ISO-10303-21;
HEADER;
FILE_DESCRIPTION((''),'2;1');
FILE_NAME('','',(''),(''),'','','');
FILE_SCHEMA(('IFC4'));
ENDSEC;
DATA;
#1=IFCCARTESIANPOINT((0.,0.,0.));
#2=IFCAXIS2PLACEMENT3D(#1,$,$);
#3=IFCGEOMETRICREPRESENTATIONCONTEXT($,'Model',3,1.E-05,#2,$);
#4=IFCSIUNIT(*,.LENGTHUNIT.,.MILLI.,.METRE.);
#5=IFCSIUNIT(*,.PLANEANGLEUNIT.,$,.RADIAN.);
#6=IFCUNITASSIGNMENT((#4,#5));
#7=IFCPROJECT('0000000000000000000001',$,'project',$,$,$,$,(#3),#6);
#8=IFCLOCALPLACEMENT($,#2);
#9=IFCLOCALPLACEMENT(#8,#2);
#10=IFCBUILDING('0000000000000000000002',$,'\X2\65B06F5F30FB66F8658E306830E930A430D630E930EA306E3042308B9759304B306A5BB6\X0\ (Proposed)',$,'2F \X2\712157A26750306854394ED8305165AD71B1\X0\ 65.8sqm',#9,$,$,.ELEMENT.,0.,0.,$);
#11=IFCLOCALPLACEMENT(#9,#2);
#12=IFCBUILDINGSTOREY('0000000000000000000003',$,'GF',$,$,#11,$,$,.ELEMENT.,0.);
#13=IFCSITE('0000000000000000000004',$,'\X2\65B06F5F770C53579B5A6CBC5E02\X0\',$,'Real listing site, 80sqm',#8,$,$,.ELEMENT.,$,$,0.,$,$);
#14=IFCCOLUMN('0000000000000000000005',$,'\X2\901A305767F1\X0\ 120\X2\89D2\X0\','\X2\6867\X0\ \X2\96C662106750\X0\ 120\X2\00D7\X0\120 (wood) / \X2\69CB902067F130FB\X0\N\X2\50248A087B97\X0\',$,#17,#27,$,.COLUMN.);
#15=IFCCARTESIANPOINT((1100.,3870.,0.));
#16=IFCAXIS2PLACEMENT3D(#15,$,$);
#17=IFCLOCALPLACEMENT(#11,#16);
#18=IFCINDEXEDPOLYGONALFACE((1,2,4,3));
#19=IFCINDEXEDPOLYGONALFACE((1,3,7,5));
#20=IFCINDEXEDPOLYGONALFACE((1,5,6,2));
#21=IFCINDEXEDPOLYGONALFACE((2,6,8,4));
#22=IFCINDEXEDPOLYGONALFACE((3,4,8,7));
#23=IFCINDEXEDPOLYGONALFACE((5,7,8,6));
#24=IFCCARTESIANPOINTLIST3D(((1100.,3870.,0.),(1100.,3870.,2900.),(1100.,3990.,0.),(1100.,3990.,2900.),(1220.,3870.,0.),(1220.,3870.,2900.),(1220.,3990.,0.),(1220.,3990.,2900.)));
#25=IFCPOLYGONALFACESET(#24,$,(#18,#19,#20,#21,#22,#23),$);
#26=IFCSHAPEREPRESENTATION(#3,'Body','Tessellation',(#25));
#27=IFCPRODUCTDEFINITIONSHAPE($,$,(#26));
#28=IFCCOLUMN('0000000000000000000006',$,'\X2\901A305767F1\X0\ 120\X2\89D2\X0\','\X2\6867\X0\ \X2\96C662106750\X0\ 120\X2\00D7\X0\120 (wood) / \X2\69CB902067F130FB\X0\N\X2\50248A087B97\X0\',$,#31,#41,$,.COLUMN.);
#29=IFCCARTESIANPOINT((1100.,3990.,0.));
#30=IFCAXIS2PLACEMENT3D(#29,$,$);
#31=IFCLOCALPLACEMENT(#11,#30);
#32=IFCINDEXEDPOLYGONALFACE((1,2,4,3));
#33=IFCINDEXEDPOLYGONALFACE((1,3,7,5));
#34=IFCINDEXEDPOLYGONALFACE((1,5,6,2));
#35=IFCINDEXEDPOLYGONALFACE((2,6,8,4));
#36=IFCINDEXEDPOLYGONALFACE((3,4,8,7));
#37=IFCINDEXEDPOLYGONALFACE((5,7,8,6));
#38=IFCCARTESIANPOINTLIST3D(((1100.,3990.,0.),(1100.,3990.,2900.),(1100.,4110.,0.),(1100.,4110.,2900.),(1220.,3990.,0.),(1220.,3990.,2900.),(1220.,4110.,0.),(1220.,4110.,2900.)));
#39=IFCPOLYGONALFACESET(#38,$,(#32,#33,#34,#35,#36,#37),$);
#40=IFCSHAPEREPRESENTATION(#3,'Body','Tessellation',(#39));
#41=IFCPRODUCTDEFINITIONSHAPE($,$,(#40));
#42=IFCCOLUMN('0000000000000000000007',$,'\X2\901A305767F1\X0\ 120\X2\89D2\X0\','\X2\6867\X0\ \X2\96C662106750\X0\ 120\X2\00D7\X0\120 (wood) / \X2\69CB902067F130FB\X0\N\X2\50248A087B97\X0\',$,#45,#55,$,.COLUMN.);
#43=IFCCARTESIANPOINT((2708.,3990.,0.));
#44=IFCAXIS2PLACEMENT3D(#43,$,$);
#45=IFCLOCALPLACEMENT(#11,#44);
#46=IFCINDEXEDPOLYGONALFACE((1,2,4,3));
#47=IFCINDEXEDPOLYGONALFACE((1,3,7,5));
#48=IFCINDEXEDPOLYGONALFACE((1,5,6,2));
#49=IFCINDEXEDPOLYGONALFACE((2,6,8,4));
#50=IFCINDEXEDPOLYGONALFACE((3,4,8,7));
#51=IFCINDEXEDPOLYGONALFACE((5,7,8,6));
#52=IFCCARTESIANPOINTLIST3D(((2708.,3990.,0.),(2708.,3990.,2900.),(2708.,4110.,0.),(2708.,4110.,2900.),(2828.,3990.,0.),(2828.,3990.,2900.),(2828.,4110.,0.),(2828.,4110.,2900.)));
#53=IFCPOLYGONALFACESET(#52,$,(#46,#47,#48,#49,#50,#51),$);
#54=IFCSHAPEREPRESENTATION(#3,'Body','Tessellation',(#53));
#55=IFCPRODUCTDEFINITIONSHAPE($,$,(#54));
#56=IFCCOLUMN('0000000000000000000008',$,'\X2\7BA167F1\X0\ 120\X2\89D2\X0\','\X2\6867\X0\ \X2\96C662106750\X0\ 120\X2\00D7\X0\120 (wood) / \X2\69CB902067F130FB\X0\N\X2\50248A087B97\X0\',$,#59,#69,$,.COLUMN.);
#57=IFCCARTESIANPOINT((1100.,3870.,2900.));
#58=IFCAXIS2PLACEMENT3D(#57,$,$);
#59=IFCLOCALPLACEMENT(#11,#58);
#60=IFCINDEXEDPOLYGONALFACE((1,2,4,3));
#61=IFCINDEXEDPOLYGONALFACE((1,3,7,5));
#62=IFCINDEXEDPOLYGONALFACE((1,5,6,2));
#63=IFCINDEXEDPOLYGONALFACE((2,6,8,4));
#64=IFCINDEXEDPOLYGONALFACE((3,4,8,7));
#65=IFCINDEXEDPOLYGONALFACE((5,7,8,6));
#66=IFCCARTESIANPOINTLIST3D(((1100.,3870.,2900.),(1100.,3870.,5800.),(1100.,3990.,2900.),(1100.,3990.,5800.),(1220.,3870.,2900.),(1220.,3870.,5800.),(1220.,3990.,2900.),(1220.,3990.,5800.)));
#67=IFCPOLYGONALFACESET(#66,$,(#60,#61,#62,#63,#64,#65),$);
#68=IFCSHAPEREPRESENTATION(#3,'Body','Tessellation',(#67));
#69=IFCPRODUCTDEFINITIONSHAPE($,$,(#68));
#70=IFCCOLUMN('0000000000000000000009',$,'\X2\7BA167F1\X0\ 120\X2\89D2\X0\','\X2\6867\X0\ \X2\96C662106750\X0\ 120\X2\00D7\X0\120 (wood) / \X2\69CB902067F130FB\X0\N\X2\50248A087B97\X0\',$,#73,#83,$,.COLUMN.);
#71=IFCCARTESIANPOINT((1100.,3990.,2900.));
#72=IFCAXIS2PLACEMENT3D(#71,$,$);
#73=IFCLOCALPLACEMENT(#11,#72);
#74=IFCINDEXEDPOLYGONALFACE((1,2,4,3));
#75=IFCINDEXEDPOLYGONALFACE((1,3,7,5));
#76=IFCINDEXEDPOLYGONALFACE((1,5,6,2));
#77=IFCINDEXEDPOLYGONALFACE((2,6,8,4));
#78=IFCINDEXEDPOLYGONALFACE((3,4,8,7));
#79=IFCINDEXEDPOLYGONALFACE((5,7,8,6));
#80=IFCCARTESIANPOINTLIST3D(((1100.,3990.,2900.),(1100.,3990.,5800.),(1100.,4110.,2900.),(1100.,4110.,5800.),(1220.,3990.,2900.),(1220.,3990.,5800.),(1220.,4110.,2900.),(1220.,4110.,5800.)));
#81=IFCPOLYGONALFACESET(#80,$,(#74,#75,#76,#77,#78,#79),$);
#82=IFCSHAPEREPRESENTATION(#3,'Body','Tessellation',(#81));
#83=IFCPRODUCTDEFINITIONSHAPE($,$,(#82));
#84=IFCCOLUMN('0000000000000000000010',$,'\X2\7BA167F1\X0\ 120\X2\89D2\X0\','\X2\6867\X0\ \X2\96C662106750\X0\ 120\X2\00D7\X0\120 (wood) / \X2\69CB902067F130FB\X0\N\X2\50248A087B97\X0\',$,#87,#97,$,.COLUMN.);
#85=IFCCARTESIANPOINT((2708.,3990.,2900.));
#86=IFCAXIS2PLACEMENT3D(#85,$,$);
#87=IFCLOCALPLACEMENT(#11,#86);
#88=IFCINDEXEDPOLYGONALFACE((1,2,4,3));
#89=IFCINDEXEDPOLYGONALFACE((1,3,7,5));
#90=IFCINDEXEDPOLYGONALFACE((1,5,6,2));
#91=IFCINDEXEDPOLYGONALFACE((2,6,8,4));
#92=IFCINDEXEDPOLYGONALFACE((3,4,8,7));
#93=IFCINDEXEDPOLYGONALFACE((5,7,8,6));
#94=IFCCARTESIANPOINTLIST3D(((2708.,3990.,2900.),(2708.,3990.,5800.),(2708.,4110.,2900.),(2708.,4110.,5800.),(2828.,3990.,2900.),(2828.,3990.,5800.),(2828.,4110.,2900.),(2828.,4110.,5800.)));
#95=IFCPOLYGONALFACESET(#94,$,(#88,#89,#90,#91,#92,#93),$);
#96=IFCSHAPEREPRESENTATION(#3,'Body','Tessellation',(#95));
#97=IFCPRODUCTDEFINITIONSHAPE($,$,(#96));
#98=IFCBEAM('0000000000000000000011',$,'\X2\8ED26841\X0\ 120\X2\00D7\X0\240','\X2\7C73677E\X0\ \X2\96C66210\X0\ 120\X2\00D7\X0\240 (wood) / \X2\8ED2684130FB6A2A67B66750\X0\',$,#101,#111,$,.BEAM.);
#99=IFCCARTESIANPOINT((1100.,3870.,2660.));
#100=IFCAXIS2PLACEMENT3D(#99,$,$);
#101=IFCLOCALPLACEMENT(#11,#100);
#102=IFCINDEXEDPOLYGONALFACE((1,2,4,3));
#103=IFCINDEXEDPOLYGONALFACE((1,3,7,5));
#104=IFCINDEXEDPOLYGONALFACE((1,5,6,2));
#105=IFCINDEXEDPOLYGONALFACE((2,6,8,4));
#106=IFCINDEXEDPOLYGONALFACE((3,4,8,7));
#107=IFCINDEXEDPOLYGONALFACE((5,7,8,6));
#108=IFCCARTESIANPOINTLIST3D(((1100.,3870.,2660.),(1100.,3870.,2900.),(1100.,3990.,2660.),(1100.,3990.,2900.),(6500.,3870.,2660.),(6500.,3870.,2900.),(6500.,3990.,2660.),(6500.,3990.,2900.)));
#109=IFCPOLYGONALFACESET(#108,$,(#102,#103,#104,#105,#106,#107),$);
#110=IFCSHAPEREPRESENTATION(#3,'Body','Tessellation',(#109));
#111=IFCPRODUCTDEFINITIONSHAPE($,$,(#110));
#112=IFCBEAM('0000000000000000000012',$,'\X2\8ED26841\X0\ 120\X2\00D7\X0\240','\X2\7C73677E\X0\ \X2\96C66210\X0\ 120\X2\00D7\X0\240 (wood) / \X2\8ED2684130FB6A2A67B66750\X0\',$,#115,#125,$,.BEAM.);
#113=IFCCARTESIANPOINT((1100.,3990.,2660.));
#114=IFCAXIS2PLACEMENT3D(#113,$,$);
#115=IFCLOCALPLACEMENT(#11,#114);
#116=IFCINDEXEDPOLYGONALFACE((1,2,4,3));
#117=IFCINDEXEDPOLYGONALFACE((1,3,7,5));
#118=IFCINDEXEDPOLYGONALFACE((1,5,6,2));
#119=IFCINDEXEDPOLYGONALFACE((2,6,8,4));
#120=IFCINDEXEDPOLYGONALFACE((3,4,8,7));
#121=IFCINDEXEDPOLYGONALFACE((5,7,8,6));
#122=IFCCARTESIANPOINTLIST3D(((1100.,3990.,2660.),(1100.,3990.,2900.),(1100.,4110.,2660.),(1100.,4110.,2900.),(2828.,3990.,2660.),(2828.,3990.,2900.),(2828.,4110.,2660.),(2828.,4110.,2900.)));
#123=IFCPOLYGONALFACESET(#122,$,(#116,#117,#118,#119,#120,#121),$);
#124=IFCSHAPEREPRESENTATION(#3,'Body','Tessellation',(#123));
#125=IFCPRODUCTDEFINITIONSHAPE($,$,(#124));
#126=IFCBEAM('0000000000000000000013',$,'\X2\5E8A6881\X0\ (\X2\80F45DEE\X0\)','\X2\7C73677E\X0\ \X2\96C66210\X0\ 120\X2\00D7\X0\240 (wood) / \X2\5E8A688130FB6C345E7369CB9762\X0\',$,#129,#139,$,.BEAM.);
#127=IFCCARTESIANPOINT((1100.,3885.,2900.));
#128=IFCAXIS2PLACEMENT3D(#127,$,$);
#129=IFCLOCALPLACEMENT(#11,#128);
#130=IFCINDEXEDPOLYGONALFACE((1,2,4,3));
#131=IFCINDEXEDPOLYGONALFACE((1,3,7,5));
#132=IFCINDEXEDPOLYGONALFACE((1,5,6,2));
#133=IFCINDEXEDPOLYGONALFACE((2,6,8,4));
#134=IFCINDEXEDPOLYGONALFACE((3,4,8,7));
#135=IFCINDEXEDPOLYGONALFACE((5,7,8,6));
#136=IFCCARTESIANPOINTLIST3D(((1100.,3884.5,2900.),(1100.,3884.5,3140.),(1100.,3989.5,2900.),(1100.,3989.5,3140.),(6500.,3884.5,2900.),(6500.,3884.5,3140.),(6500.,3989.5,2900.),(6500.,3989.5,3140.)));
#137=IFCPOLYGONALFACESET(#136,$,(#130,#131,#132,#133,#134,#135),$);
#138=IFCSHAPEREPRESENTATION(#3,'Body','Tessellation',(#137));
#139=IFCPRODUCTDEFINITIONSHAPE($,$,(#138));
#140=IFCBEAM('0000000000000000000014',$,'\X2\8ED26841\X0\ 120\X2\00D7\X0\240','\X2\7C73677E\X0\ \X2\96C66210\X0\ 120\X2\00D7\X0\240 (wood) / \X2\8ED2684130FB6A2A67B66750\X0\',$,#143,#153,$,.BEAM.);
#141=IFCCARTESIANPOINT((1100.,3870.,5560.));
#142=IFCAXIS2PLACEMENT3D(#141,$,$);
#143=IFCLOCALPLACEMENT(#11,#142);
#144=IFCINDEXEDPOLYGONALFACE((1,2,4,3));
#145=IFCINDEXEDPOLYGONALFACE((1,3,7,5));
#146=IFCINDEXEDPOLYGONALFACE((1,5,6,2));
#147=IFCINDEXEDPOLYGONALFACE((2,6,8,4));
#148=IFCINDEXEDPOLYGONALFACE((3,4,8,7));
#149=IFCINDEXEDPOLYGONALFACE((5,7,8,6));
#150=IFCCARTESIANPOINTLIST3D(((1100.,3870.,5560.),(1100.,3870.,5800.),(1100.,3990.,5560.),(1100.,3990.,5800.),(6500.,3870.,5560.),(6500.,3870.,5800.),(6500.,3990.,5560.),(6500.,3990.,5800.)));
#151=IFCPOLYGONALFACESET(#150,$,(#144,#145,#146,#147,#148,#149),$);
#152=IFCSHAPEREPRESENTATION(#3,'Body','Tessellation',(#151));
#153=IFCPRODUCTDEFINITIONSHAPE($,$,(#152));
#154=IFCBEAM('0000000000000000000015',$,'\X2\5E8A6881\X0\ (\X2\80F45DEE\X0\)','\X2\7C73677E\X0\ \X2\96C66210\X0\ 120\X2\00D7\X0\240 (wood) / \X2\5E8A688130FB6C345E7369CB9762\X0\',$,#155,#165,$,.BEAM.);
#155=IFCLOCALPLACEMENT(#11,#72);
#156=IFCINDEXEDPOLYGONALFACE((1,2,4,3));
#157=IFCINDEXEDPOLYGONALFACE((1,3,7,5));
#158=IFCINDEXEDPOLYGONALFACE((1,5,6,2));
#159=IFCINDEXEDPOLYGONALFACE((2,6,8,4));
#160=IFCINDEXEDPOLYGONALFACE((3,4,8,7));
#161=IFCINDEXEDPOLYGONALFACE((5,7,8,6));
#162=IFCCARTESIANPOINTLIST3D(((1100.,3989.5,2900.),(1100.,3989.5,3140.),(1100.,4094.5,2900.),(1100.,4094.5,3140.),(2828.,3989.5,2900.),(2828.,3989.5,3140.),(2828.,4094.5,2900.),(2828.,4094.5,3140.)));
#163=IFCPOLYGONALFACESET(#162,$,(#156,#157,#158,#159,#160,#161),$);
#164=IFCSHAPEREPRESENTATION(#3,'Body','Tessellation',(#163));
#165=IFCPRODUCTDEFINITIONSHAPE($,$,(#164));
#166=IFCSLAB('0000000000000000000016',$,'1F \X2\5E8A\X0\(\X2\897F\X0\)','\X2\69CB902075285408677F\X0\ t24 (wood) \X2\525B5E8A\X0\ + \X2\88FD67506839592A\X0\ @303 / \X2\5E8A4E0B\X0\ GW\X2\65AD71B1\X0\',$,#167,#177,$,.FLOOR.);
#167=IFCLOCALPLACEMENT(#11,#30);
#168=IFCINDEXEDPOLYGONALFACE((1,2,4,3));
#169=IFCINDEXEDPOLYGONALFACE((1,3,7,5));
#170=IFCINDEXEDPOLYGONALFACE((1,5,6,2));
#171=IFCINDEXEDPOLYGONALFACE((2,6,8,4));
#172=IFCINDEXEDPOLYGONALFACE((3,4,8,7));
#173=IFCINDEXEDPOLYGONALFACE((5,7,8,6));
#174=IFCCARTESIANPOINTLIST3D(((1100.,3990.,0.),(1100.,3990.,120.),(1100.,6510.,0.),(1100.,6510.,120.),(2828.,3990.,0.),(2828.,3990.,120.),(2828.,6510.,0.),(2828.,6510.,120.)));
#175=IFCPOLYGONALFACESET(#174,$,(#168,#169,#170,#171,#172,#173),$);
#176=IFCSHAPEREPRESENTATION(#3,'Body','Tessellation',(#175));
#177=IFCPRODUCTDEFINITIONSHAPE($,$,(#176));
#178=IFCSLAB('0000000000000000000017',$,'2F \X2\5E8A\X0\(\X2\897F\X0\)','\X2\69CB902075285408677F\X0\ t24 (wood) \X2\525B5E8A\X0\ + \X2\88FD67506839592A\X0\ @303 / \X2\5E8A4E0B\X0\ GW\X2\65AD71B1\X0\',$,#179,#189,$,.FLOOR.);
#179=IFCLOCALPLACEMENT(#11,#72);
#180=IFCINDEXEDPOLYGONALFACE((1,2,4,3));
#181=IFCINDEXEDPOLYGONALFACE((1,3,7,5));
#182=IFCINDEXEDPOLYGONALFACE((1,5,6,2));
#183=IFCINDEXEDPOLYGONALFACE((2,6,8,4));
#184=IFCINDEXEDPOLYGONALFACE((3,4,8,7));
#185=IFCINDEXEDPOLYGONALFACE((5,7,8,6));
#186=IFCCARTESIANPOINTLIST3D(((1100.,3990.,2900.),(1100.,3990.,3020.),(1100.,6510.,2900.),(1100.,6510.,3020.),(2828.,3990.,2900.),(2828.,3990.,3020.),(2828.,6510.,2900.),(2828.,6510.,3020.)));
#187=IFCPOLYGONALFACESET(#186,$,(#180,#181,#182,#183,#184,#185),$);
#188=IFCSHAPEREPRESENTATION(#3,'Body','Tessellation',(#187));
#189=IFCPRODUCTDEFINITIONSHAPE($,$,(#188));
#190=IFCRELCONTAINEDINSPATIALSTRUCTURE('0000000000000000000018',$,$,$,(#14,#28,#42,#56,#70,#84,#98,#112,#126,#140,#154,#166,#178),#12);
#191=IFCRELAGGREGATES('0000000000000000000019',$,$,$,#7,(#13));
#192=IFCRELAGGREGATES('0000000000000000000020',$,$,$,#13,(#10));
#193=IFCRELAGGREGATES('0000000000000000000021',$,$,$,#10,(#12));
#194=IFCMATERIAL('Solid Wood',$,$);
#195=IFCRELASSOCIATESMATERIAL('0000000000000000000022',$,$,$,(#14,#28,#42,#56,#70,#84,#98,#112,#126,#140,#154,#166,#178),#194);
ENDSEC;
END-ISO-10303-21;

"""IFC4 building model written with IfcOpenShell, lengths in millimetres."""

from ifc_helpers import new_model, si_unit, frame, frame_2d, origin, place, context, project, spatial, rectangle, extrude, material, element, save


model = new_model("IFC4")

# Units and contexts
model_context = context("Model", 3, precision=1e-05, world=origin())
ifc_project = project(units=[si_unit("LENGTHUNIT", "METRE", prefix="MILLI"), si_unit("PLANEANGLEUNIT", "RADIAN")], contexts=[model_context])

# Site, building, storey
site_placement = place(None, origin())
site = spatial("IfcSite", under=ifc_project, at=site_placement, Name="新潟県南魚沼市", ObjectType="Real listing site, 80sqm", CompositionType="ELEMENT", RefElevation=0.0)
building_placement = place(site_placement, origin())
building = spatial("IfcBuilding", under=site, at=building_placement, Name="新潟・書斎とライブラリのある静かな家 (Proposed)", ObjectType="2F 無垢材と吹付け断熱 65.8sqm", CompositionType="ELEMENT", ElevationOfRefHeight=0.0, ElevationOfTerrain=0.0)
storey_placement = place(building_placement, origin())
storey = spatial("IfcBuildingStorey", under=building, at=storey_placement, Name="GF", CompositionType="ELEMENT", Elevation=0.0)

# Columns
ifc_material_1 = material(Name="Solid Wood")
column_1_placement = place(storey_placement, frame((1100.0, 3870.0, 0.0)))
element("IfcColumn", 1, at=column_1_placement, inside=storey, material=ifc_material_1, Name="通し柱 120角", Description="桧 集成材 120×120 (wood) / 構造柱・N値計算", PredefinedType="COLUMN", context=model_context, shape_type="SweptSolid", body=[
    extrude(rectangle(XDim=120.0, YDim=120.0, at=frame_2d((60.0, 60.0))), frame((1100.0, 3870.0, 0.0)), (0.0, 0.0, 1.0), 2900.0),
])
column_2_placement = place(storey_placement, frame((1100.0, 3990.0, 0.0)))
element("IfcColumn", 2, at=column_2_placement, inside=storey, material=ifc_material_1, Name="通し柱 120角", Description="桧 集成材 120×120 (wood) / 構造柱・N値計算", PredefinedType="COLUMN", context=model_context, shape_type="SweptSolid", body=[
    extrude(rectangle(XDim=120.0, YDim=120.0, at=frame_2d((60.0, 60.0))), frame((1100.0, 3990.0, 0.0)), (0.0, 0.0, 1.0), 2900.0),
])
column_3_placement = place(storey_placement, frame((2708.0, 3990.0, 0.0)))
element("IfcColumn", 3, at=column_3_placement, inside=storey, material=ifc_material_1, Name="通し柱 120角", Description="桧 集成材 120×120 (wood) / 構造柱・N値計算", PredefinedType="COLUMN", context=model_context, shape_type="SweptSolid", body=[
    extrude(rectangle(XDim=120.0, YDim=120.0, at=frame_2d((60.0, 60.0))), frame((2708.0, 3990.0, 0.0)), (0.0, 0.0, 1.0), 2900.0),
])
column_4_placement = place(storey_placement, frame((1100.0, 3870.0, 2900.0)))
element("IfcColumn", 4, at=column_4_placement, inside=storey, material=ifc_material_1, Name="管柱 120角", Description="桧 集成材 120×120 (wood) / 構造柱・N値計算", PredefinedType="COLUMN", context=model_context, shape_type="SweptSolid", body=[
    extrude(rectangle(XDim=120.0, YDim=120.0, at=frame_2d((60.0, 60.0))), frame((1100.0, 3870.0, 2900.0)), (0.0, 0.0, 1.0), 2900.0),
])
column_5_placement = place(storey_placement, frame((1100.0, 3990.0, 2900.0)))
element("IfcColumn", 5, at=column_5_placement, inside=storey, material=ifc_material_1, Name="管柱 120角", Description="桧 集成材 120×120 (wood) / 構造柱・N値計算", PredefinedType="COLUMN", context=model_context, shape_type="SweptSolid", body=[
    extrude(rectangle(XDim=120.0, YDim=120.0, at=frame_2d((60.0, 60.0))), frame((1100.0, 3990.0, 2900.0)), (0.0, 0.0, 1.0), 2900.0),
])
column_6_placement = place(storey_placement, frame((2708.0, 3990.0, 2900.0)))
element("IfcColumn", 6, at=column_6_placement, inside=storey, material=ifc_material_1, Name="管柱 120角", Description="桧 集成材 120×120 (wood) / 構造柱・N値計算", PredefinedType="COLUMN", context=model_context, shape_type="SweptSolid", body=[
    extrude(rectangle(XDim=120.0, YDim=120.0, at=frame_2d((60.0, 60.0))), frame((2708.0, 3990.0, 2900.0)), (0.0, 0.0, 1.0), 2900.0),
])

# Beams
beam_1_placement = place(storey_placement, frame((1100.0, 3870.0, 2660.0)))
element("IfcBeam", 7, at=beam_1_placement, inside=storey, material=ifc_material_1, Name="軒桁 120×240", Description="米松 集成 120×240 (wood) / 軒桁・横架材", PredefinedType="BEAM", context=model_context, shape_type="SweptSolid", body=[
    extrude(rectangle(XDim=5400.0, YDim=120.0, at=frame_2d((2700.0, 60.0))), frame((1100.0, 3870.0, 2660.0)), (0.0, 0.0, 1.0), 240.0),
])
beam_2_placement = place(storey_placement, frame((1100.0, 3990.0, 2660.0)))
element("IfcBeam", 8, at=beam_2_placement, inside=storey, material=ifc_material_1, Name="軒桁 120×240", Description="米松 集成 120×240 (wood) / 軒桁・横架材", PredefinedType="BEAM", context=model_context, shape_type="SweptSolid", body=[
    extrude(rectangle(XDim=1728.0, YDim=120.0, at=frame_2d((864.0, 60.0))), frame((1100.0, 3990.0, 2660.0)), (0.0, 0.0, 1.0), 240.0),
])
beam_3_placement = place(storey_placement, frame((1100.0, 3885.0, 2900.0)))
element("IfcBeam", 9, at=beam_3_placement, inside=storey, material=ifc_material_1, Name="床梁 (胴差)", Description="米松 集成 120×240 (wood) / 床梁・水平構面", PredefinedType="BEAM", context=model_context, shape_type="SweptSolid", body=[
    extrude(rectangle(XDim=5400.0, YDim=105.0, at=frame_2d((2700.0, 52.0))), frame((1100.0, 3885.0, 2900.0)), (0.0, 0.0, 1.0), 240.0),
])
beam_4_placement = place(storey_placement, frame((1100.0, 3870.0, 5560.0)))
element("IfcBeam", 10, at=beam_4_placement, inside=storey, material=ifc_material_1, Name="軒桁 120×240", Description="米松 集成 120×240 (wood) / 軒桁・横架材", PredefinedType="BEAM", context=model_context, shape_type="SweptSolid", body=[
    extrude(rectangle(XDim=5400.0, YDim=120.0, at=frame_2d((2700.0, 60.0))), frame((1100.0, 3870.0, 5560.0)), (0.0, 0.0, 1.0), 240.0),
])
beam_5_placement = place(storey_placement, frame((1100.0, 3990.0, 2900.0)))
element("IfcBeam", 11, at=beam_5_placement, inside=storey, material=ifc_material_1, Name="床梁 (胴差)", Description="米松 集成 120×240 (wood) / 床梁・水平構面", PredefinedType="BEAM", context=model_context, shape_type="SweptSolid", body=[
    extrude(rectangle(XDim=1728.0, YDim=105.0, at=frame_2d((864.0, 52.0))), frame((1100.0, 3990.0, 2900.0)), (0.0, 0.0, 1.0), 240.0),
])

# Slabs
slab_1_placement = place(storey_placement, frame((1100.0, 3990.0, 0.0)))
element("IfcSlab", 12, at=slab_1_placement, inside=storey, material=ifc_material_1, Name="1F 床(西)", Description="構造用合板 t24 (wood) 剛床 + 製材根太 @303 / 床下 GW断熱", PredefinedType="FLOOR", context=model_context, shape_type="SweptSolid", body=[
    extrude(rectangle(XDim=1728.0, YDim=2520.0, at=frame_2d((864.0, 1260.0))), frame((1100.0, 3990.0, 0.0)), (0.0, 0.0, 1.0), 120.0),
])
slab_2_placement = place(storey_placement, frame((1100.0, 3990.0, 2900.0)))
element("IfcSlab", 13, at=slab_2_placement, inside=storey, material=ifc_material_1, Name="2F 床(西)", Description="構造用合板 t24 (wood) 剛床 + 製材根太 @303 / 床下 GW断熱", PredefinedType="FLOOR", context=model_context, shape_type="SweptSolid", body=[
    extrude(rectangle(XDim=1728.0, YDim=2520.0, at=frame_2d((864.0, 1260.0))), frame((1100.0, 3990.0, 2900.0)), (0.0, 0.0, 1.0), 120.0),
])

save(model, "model.ifc")
